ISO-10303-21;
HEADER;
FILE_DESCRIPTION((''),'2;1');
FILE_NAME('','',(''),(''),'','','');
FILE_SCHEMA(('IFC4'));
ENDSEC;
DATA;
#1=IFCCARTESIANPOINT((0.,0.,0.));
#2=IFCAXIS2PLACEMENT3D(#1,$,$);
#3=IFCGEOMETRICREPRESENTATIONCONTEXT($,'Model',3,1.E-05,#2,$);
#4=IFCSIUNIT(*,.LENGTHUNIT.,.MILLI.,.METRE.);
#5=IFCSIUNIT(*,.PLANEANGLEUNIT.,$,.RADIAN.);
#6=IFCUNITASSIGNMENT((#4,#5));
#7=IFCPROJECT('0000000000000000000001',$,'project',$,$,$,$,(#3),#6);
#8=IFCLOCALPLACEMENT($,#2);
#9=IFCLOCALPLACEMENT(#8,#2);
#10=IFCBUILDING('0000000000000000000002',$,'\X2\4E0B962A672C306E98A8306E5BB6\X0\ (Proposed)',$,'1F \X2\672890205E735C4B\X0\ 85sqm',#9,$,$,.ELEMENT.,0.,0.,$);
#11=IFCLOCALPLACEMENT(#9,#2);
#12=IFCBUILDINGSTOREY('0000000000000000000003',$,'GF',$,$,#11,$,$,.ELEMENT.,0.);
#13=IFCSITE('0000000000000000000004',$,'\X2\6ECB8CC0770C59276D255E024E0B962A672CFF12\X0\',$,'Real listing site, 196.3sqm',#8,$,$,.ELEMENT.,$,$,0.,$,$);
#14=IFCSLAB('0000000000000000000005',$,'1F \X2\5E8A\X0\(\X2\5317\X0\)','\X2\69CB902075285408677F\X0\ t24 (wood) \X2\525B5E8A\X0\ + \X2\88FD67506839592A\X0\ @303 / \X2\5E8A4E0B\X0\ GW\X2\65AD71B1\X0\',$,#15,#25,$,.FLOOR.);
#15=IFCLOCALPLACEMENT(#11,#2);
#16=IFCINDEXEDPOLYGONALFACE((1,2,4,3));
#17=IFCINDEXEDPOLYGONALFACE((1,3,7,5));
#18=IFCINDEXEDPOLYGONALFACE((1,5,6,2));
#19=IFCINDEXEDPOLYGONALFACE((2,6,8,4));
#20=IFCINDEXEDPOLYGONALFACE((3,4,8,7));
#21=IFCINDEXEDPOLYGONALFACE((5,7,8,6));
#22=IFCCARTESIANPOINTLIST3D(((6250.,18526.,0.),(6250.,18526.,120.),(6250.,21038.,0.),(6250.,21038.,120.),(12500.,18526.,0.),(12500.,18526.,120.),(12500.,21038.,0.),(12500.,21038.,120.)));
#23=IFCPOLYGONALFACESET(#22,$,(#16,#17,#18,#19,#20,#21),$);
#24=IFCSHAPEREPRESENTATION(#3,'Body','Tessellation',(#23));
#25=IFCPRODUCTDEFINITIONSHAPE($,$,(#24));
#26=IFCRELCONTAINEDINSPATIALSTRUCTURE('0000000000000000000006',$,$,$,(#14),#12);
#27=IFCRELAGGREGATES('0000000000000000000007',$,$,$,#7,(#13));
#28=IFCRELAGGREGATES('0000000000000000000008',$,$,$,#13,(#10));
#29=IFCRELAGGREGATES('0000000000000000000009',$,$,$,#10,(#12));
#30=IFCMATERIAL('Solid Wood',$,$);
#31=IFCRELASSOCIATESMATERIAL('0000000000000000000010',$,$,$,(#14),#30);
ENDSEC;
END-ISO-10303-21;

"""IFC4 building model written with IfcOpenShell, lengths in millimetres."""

from ifc_helpers import new_model, si_unit, frame, frame_2d, origin, place, context, project, spatial, rectangle, extrude, material, element, save


model = new_model("IFC4")

# Units and contexts
model_context = context("Model", 3, precision=1e-05, world=origin())
ifc_project = project(units=[si_unit("LENGTHUNIT", "METRE", prefix="MILLI"), si_unit("PLANEANGLEUNIT", "RADIAN")], contexts=[model_context])

# Site, building, storey
site_placement = place(None, origin())
site = spatial("IfcSite", under=ifc_project, at=site_placement, Name="滋賀県大津市下阪本２", ObjectType="Real listing site, 196.3sqm", CompositionType="ELEMENT", RefElevation=0.0)
building_placement = place(site_placement, origin())
building = spatial("IfcBuilding", under=site, at=building_placement, Name="下阪本の風の家 (Proposed)", ObjectType="1F 木造平屋 85sqm", CompositionType="ELEMENT", ElevationOfRefHeight=0.0, ElevationOfTerrain=0.0)
storey_placement = place(building_placement, origin())
storey = spatial("IfcBuildingStorey", under=building, at=storey_placement, Name="GF", CompositionType="ELEMENT", Elevation=0.0)

# Slab
ifc_material_1 = material(Name="Solid Wood")
slab_1_placement = place(storey_placement, frame((3125.0, 9263.0, 0.0)))
element("IfcSlab", 1, at=slab_1_placement, inside=storey, material=ifc_material_1, Name="1F 床(北)", Description="構造用合板 t24 (wood) 剛床 + 製材根太 @303 / 床下 GW断熱", PredefinedType="FLOOR", context=model_context, shape_type="SweptSolid", body=[
    extrude(rectangle(XDim=6250.0, YDim=2512.0, at=frame_2d((3125.0, 1256.0))), frame((3125.0, 9263.0, 0.0)), (0.0, 0.0, 1.0), 120.0),
])

save(model, "model.ifc")
